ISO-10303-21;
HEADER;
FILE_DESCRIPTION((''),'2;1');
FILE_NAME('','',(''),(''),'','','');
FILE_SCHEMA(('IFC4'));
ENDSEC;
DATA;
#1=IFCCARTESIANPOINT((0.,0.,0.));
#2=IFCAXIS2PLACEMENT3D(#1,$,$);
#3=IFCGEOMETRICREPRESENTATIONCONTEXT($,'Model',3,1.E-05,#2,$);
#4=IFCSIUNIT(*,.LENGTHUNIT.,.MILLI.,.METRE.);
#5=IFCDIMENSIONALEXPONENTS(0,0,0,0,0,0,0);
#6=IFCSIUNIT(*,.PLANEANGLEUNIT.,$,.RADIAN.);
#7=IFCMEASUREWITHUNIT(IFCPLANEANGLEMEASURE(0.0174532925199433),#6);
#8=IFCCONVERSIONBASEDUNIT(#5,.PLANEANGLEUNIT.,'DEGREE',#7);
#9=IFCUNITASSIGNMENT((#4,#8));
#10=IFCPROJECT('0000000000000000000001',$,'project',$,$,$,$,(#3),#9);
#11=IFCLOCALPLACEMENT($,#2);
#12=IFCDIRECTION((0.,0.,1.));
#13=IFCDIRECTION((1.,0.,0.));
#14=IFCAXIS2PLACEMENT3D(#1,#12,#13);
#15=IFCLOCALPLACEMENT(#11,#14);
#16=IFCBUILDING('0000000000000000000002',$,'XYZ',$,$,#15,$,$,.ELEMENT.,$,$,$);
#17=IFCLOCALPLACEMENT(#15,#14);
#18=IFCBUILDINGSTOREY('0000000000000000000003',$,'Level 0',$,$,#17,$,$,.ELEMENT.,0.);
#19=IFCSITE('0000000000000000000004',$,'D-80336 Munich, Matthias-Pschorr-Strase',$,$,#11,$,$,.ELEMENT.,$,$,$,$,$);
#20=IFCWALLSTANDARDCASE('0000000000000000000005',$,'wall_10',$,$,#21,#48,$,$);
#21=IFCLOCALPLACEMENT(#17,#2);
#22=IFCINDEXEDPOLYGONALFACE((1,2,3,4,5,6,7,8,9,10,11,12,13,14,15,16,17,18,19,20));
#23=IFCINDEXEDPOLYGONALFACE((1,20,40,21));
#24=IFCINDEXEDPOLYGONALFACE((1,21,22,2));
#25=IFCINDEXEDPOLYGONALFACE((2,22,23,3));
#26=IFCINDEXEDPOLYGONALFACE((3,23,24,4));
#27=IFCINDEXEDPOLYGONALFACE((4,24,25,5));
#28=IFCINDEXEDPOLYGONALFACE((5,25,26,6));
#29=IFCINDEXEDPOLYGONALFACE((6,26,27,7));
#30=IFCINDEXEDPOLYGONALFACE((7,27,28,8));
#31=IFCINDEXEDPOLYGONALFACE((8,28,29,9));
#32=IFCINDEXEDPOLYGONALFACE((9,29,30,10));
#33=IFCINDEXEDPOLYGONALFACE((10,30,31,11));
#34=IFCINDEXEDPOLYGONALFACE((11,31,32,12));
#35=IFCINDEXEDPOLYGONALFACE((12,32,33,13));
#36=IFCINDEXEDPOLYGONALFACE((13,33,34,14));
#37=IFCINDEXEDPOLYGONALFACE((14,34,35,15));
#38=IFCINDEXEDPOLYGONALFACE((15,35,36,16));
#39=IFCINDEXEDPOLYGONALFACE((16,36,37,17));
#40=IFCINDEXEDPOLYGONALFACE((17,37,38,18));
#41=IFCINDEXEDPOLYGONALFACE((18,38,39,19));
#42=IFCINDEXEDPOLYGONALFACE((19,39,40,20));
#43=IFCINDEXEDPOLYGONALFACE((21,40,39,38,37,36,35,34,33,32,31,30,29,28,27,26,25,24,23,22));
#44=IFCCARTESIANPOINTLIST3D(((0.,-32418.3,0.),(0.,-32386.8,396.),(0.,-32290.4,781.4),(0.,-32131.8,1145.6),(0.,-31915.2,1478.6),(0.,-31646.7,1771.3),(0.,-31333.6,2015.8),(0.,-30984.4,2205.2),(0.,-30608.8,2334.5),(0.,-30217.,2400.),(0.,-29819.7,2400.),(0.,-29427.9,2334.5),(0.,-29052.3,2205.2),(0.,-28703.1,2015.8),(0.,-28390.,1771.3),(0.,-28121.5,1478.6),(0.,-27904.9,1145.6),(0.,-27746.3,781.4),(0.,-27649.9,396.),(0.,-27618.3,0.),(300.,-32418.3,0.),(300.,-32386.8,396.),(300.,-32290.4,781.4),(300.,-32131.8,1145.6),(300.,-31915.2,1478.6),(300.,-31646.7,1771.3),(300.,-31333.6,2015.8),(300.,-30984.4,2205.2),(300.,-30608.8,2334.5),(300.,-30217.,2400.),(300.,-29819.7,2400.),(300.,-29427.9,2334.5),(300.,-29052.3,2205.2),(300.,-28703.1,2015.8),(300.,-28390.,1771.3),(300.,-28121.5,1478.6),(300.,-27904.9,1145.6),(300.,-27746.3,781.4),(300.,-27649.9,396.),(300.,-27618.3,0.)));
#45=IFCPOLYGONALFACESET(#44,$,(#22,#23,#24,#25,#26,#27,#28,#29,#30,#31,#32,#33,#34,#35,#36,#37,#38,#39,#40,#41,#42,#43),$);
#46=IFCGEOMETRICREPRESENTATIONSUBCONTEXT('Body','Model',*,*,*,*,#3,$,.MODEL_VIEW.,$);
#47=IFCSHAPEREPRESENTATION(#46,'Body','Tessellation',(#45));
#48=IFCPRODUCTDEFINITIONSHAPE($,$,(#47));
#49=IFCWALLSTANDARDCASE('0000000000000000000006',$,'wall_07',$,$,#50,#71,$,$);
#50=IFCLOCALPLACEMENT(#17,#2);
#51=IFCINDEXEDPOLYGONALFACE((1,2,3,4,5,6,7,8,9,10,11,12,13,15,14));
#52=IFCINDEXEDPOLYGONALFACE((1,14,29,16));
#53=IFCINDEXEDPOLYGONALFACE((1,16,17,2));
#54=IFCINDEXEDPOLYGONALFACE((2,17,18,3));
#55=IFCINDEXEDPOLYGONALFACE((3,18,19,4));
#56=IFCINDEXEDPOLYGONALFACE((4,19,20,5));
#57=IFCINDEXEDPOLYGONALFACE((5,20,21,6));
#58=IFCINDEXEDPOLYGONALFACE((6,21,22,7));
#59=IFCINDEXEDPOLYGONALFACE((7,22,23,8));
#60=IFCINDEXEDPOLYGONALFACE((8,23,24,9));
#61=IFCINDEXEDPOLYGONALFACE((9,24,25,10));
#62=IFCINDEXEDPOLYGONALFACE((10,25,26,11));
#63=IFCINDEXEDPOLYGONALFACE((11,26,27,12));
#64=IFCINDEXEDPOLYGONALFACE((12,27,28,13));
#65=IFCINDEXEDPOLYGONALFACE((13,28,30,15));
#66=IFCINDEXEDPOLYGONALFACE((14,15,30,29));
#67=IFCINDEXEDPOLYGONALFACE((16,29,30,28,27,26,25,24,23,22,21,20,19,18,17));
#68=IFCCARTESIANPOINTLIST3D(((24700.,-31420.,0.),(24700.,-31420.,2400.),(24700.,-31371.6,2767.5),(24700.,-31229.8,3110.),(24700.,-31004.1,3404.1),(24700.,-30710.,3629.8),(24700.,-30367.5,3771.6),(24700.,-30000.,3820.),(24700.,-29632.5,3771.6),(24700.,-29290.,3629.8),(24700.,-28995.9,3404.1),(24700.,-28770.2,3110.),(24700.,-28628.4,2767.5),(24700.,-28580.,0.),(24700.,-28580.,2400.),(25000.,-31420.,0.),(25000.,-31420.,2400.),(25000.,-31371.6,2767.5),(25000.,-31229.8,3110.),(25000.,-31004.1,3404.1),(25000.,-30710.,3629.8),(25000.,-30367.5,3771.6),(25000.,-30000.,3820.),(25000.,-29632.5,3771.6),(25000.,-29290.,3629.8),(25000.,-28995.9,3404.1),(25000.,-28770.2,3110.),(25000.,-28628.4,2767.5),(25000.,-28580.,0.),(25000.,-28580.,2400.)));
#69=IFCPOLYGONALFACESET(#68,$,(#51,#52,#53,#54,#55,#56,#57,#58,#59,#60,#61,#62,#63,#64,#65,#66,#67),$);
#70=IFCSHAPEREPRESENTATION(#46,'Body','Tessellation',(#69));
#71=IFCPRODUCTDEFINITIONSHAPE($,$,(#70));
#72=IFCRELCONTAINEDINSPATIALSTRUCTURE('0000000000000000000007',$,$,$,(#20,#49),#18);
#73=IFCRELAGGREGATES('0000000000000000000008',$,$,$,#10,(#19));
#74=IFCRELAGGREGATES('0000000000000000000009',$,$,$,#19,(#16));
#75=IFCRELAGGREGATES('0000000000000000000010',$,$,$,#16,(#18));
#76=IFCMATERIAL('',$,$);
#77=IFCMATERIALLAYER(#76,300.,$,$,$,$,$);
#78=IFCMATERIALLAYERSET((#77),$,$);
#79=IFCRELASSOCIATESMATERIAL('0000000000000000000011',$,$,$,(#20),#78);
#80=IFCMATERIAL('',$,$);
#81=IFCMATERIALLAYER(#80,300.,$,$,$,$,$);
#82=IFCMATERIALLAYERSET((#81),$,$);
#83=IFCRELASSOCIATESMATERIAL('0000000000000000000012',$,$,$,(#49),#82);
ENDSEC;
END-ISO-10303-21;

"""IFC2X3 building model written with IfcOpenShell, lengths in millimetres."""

from ifc_helpers import new_model, entity, si_unit, converted_unit, frame, frame_2d, origin, origin_with_axes, place, context, subcontext, project, spatial, polyline, rectangle, extrude, clip, bounded_halfspace, material, layer, layer_set, layer_usage, element, save


model = new_model("IFC2X3")

# Units and contexts
model_context = context("Model", 3, precision=1e-05, world=origin())
body_context = subcontext(model_context, "Body", "Model", "MODEL_VIEW")
ifc_project = project(units=[si_unit("LENGTHUNIT", "METRE", prefix="MILLI"), converted_unit("PLANEANGLEUNIT", "DEGREE", entity("IfcPlaneAngleMeasure", 0.0174532925199433), si_unit("PLANEANGLEUNIT", "RADIAN"), dimensions=[0, 0, 0, 0, 0, 0, 0])], contexts=[model_context])

# Site, building, storey
site_placement = place(None, origin())
site = spatial("IfcSite", under=ifc_project, at=site_placement, Name="D-80336 Munich, Matthias-Pschorr-Strase", CompositionType="ELEMENT")
building_placement = place(site_placement, origin_with_axes())
building = spatial("IfcBuilding", under=site, at=building_placement, Name="XYZ", CompositionType="ELEMENT")
storey_placement = place(building_placement, origin_with_axes())
storey = spatial("IfcBuildingStorey", under=building, at=storey_placement, Name="Level 0", CompositionType="ELEMENT", Elevation=0.0)

# Walls
ifc_material_1 = material(Name="")
ifc_layer_1 = layer(ifc_material_1, 300.0)
ifc_layer_set_1 = layer_set([ifc_layer_1])
ifc_layer_usage_1 = layer_usage(ifc_layer_set_1, "AXIS2", "POSITIVE", 0.0)
wall_1_placement = place(storey_placement, frame((0.0, -27618.3, 0.0), z_axis=(0.0, 0.0, 1.0), x_axis=(0.0, -1.0, 0.0)))
solid_1 = clip(clip(clip(clip(clip(clip(clip(clip(extrude(rectangle(XDim=4800.0, YDim=300.0, at=frame_2d((2400.0, 150.0), x_axis=(1.0, 0.0))), origin_with_axes(), (0.0, 0.0, 1.0), 2400.0), bounded_halfspace(frame((1809.6, 0.0, 2334.5), z_axis=(0.16495, 0.0, -0.986302), x_axis=(0.986302, 0.0, 0.16495)), True, origin(), polyline([(1809.6, 0.0), (2201.4, 0.0), (2201.4, 300.0), (1809.6, 300.0), (1809.6, 0.0)]))), bounded_halfspace(frame((31.5, 300.0, 396.0), z_axis=(0.996847, 0.0, -0.079345), x_axis=(-0.079345, 0.0, -0.996847)), True, origin(), polyline([(31.5, 300.0), (0.0, 300.0), (0.0, 0.0), (31.5, 0.0), (31.5, 300.0)]))), bounded_halfspace(frame((127.9, 300.0, 781.4), z_axis=(0.970104, 0.0, -0.242689), x_axis=(-0.242689, 0.0, -0.970104)), True, origin(), polyline([(127.9, 300.0), (31.5, 300.0), (31.5, 0.0), (127.9, 0.0), (127.9, 300.0)]))), bounded_halfspace(frame((286.6, 300.0, 1145.6), z_axis=(0.916784, 0.0, -0.399383), x_axis=(-0.399383, 0.0, -0.916784)), True, origin(), polyline([(286.6, 300.0), (127.9, 300.0), (127.9, 0.0), (286.6, 0.0), (286.6, 300.0)]))), bounded_halfspace(frame((503.1, 300.0, 1478.6), z_axis=(0.838347, 0.0, -0.545136), x_axis=(-0.545136, 0.0, -0.838347)), True, origin(), polyline([(503.1, 300.0), (286.6, 300.0), (286.6, 0.0), (503.1, 0.0), (503.1, 300.0)]))), bounded_halfspace(frame((771.7, 300.0, 1771.3), z_axis=(0.736943, 0.0, -0.675954), x_axis=(-0.675954, 0.0, -0.736943)), True, origin(), polyline([(771.7, 300.0), (503.1, 300.0), (503.1, 0.0), (771.7, 0.0), (771.7, 300.0)]))), bounded_halfspace(frame((1084.8, 300.0, 2015.8), z_axis=(0.61535, 0.0, -0.788254), x_axis=(-0.788254, 0.0, -0.61535)), True, origin(), polyline([(1084.8, 300.0), (771.7, 300.0), (771.7, 0.0), (1084.8, 0.0), (1084.8, 300.0)]))), bounded_halfspace(frame((1433.9, 300.0, 2205.2), z_axis=(0.476898, 0.0, -0.878959), x_axis=(-0.878959, 0.0, -0.476898)), True, origin(), polyline([(1433.9, 300.0), (1084.8, 300.0), (1084.8, 0.0), (1433.9, 0.0), (1433.9, 300.0)])))
solid_2 = clip(clip(clip(clip(clip(clip(clip(clip(solid_1, bounded_halfspace(frame((1433.9, 300.0, 2205.2), z_axis=(0.325381, 0.0, -0.945583), x_axis=(0.0, -1.0, 0.0)), True, origin(), polyline([(1433.9, 300.0), (1433.9, 0.0), (1809.6, 0.0), (1809.6, 300.0), (1433.9, 300.0)]))), bounded_halfspace(frame((2598.6, 300.0, 2400.0), z_axis=(0.0, 0.0, -1.0), x_axis=(-1.0, 0.0, 0.0)), True, origin(), polyline([(2598.6, 300.0), (2201.4, 300.0), (2201.4, 0.0), (2598.6, 0.0), (2598.6, 300.0)]))), bounded_halfspace(frame((2990.4, 300.0, 2334.5), z_axis=(-0.16495, 0.0, -0.986302), x_axis=(-0.986302, 0.0, 0.16495)), True, origin(), polyline([(2990.4, 300.0), (2598.6, 300.0), (2598.6, 0.0), (2990.4, 0.0), (2990.4, 300.0)]))), bounded_halfspace(frame((3366.1, 300.0, 2205.2), z_axis=(-0.325381, 0.0, -0.945583), x_axis=(-0.945583, 0.0, 0.325381)), True, origin(), polyline([(3366.1, 300.0), (2990.4, 300.0), (2990.4, 0.0), (3366.1, 0.0), (3366.1, 300.0)]))), bounded_halfspace(frame((3715.2, 300.0, 2015.8), z_axis=(-0.476898, 0.0, -0.878959), x_axis=(-0.878959, 0.0, 0.476898)), True, origin(), polyline([(3715.2, 300.0), (3366.1, 300.0), (3366.1, 0.0), (3715.2, 0.0), (3715.2, 300.0)]))), bounded_halfspace(frame((4028.3, 300.0, 1771.3), z_axis=(-0.61535, 0.0, -0.788254), x_axis=(-0.788254, 0.0, 0.61535)), True, origin(), polyline([(4028.3, 300.0), (3715.2, 300.0), (3715.2, 0.0), (4028.3, 0.0), (4028.3, 300.0)]))), bounded_halfspace(frame((4296.9, 300.0, 1478.6), z_axis=(-0.736943, 0.0, -0.675954), x_axis=(-0.675954, 0.0, 0.736943)), True, origin(), polyline([(4296.9, 300.0), (4028.3, 300.0), (4028.3, 0.0), (4296.9, 0.0), (4296.9, 300.0)]))), bounded_halfspace(frame((4513.4, 300.0, 1145.6), z_axis=(-0.838347, 0.0, -0.545136), x_axis=(-0.545136, 0.0, 0.838347)), True, origin(), polyline([(4513.4, 300.0), (4296.9, 300.0), (4296.9, 0.0), (4513.4, 0.0), (4513.4, 300.0)])))
element("IfcWallStandardCase", 1, at=wall_1_placement, inside=storey, material=ifc_layer_usage_1, Name="wall_10", context=body_context, shape_type="Clipping", body=[
    clip(clip(clip(solid_2, bounded_halfspace(frame((4672.1, 300.0, 781.4), z_axis=(-0.916784, 0.0, -0.399383), x_axis=(-0.399383, 0.0, 0.916784)), True, origin(), polyline([(4672.1, 300.0), (4513.4, 300.0), (4513.4, 0.0), (4672.1, 0.0), (4672.1, 300.0)]))), bounded_halfspace(frame((4768.5, 300.0, 396.0), z_axis=(-0.970104, 0.0, -0.242689), x_axis=(-0.242689, 0.0, 0.970104)), True, origin(), polyline([(4768.5, 300.0), (4672.1, 300.0), (4672.1, 0.0), (4768.5, 0.0), (4768.5, 300.0)]))), bounded_halfspace(frame((4768.5, 300.0, 396.0), z_axis=(-0.996847, 0.0, -0.079345), x_axis=(0.0, -1.0, 0.0)), True, origin(), polyline([(4768.5, 300.0), (4768.5, 0.0), (4800.0, 0.0), (4800.0, 300.0), (4768.5, 300.0)]))),
])
ifc_material_2 = material(Name="")
ifc_layer_2 = layer(ifc_material_2, 300.0)
ifc_layer_set_2 = layer_set([ifc_layer_2])
ifc_layer_usage_2 = layer_usage(ifc_layer_set_2, "AXIS2", "POSITIVE", 0.0)
wall_2_placement = place(storey_placement, frame((25000.0, -31420.0, 0.0), z_axis=(0.0, 0.0, 1.0), x_axis=(0.0, 1.0, 0.0)))
solid_3 = clip(clip(clip(clip(clip(clip(clip(clip(extrude(rectangle(XDim=2840.0, YDim=300.0, at=frame_2d((1420.0, 150.0), x_axis=(1.0, 0.0))), origin_with_axes(), (0.0, 0.0, 1.0), 3820.0), bounded_halfspace(frame((1052.5, 0.0, 3771.6), z_axis=(0.130526, 0.0, -0.991445), x_axis=(0.991445, 0.0, 0.130526)), True, origin(), polyline([(1052.5, 0.0), (1420.0, 0.0), (1420.0, 300.0), (1052.5, 300.0), (1052.5, 0.0)]))), bounded_halfspace(frame((710.0, 0.0, 3629.8), z_axis=(0.382683, 0.0, -0.92388), x_axis=(0.92388, 0.0, 0.382683)), True, origin(), polyline([(710.0, 0.0), (1052.5, 0.0), (1052.5, 300.0), (710.0, 300.0), (710.0, 0.0)]))), bounded_halfspace(frame((415.9, 0.0, 3404.1), z_axis=(0.608761, 0.0, -0.793353), x_axis=(0.793353, 0.0, 0.608761)), True, origin(), polyline([(415.9, 0.0), (710.0, 0.0), (710.0, 300.0), (415.9, 300.0), (415.9, 0.0)]))), bounded_halfspace(frame((190.2, 0.0, 3110.0), z_axis=(0.793353, 0.0, -0.608761), x_axis=(0.608761, 0.0, 0.793353)), True, origin(), polyline([(190.2, 0.0), (415.9, 0.0), (415.9, 300.0), (190.2, 300.0), (190.2, 0.0)]))), bounded_halfspace(frame((48.4, 0.0, 2767.5), z_axis=(0.92388, 0.0, -0.382683), x_axis=(0.382683, 0.0, 0.92388)), True, origin(), polyline([(48.4, 0.0), (190.2, 0.0), (190.2, 300.0), (48.4, 300.0), (48.4, 0.0)]))), bounded_halfspace(frame((48.4, 0.0, 2767.5), z_axis=(0.991445, 0.0, -0.130526), x_axis=(0.0, 1.0, 0.0)), True, origin(), polyline([(48.4, 0.0), (48.4, 300.0), (0.0, 300.0), (0.0, 0.0), (48.4, 0.0)]))), bounded_halfspace(frame((1787.5, 300.0, 3771.6), z_axis=(-0.130526, 0.0, -0.991445), x_axis=(-0.991445, 0.0, 0.130526)), True, origin(), polyline([(1787.5, 300.0), (1420.0, 300.0), (1420.0, 0.0), (1787.5, 0.0), (1787.5, 300.0)]))), bounded_halfspace(frame((2130.0, 300.0, 3629.8), z_axis=(-0.382683, 0.0, -0.92388), x_axis=(-0.92388, 0.0, 0.382683)), True, origin(), polyline([(2130.0, 300.0), (1787.5, 300.0), (1787.5, 0.0), (2130.0, 0.0), (2130.0, 300.0)])))
element("IfcWallStandardCase", 2, at=wall_2_placement, inside=storey, material=ifc_layer_usage_2, Name="wall_07", context=body_context, shape_type="Clipping", body=[
    clip(clip(clip(clip(solid_3, bounded_halfspace(frame((2424.1, 300.0, 3404.1), z_axis=(-0.608761, 0.0, -0.793353), x_axis=(-0.793353, 0.0, 0.608761)), True, origin(), polyline([(2424.1, 300.0), (2130.0, 300.0), (2130.0, 0.0), (2424.1, 0.0), (2424.1, 300.0)]))), bounded_halfspace(frame((2649.8, 300.0, 3110.0), z_axis=(-0.793353, 0.0, -0.608761), x_axis=(-0.608761, 0.0, 0.793353)), True, origin(), polyline([(2649.8, 300.0), (2424.1, 300.0), (2424.1, 0.0), (2649.8, 0.0), (2649.8, 300.0)]))), bounded_halfspace(frame((2791.6, 300.0, 2767.5), z_axis=(-0.92388, 0.0, -0.382683), x_axis=(-0.382683, 0.0, 0.92388)), True, origin(), polyline([(2791.6, 300.0), (2649.8, 300.0), (2649.8, 0.0), (2791.6, 0.0), (2791.6, 300.0)]))), bounded_halfspace(frame((2791.6, 300.0, 2767.5), z_axis=(-0.991445, 0.0, -0.130526), x_axis=(0.0, -1.0, 0.0)), True, origin(), polyline([(2791.6, 300.0), (2791.6, 0.0), (2840.0, 0.0), (2840.0, 300.0), (2791.6, 300.0)]))),
])

save(model, "model.ifc")
